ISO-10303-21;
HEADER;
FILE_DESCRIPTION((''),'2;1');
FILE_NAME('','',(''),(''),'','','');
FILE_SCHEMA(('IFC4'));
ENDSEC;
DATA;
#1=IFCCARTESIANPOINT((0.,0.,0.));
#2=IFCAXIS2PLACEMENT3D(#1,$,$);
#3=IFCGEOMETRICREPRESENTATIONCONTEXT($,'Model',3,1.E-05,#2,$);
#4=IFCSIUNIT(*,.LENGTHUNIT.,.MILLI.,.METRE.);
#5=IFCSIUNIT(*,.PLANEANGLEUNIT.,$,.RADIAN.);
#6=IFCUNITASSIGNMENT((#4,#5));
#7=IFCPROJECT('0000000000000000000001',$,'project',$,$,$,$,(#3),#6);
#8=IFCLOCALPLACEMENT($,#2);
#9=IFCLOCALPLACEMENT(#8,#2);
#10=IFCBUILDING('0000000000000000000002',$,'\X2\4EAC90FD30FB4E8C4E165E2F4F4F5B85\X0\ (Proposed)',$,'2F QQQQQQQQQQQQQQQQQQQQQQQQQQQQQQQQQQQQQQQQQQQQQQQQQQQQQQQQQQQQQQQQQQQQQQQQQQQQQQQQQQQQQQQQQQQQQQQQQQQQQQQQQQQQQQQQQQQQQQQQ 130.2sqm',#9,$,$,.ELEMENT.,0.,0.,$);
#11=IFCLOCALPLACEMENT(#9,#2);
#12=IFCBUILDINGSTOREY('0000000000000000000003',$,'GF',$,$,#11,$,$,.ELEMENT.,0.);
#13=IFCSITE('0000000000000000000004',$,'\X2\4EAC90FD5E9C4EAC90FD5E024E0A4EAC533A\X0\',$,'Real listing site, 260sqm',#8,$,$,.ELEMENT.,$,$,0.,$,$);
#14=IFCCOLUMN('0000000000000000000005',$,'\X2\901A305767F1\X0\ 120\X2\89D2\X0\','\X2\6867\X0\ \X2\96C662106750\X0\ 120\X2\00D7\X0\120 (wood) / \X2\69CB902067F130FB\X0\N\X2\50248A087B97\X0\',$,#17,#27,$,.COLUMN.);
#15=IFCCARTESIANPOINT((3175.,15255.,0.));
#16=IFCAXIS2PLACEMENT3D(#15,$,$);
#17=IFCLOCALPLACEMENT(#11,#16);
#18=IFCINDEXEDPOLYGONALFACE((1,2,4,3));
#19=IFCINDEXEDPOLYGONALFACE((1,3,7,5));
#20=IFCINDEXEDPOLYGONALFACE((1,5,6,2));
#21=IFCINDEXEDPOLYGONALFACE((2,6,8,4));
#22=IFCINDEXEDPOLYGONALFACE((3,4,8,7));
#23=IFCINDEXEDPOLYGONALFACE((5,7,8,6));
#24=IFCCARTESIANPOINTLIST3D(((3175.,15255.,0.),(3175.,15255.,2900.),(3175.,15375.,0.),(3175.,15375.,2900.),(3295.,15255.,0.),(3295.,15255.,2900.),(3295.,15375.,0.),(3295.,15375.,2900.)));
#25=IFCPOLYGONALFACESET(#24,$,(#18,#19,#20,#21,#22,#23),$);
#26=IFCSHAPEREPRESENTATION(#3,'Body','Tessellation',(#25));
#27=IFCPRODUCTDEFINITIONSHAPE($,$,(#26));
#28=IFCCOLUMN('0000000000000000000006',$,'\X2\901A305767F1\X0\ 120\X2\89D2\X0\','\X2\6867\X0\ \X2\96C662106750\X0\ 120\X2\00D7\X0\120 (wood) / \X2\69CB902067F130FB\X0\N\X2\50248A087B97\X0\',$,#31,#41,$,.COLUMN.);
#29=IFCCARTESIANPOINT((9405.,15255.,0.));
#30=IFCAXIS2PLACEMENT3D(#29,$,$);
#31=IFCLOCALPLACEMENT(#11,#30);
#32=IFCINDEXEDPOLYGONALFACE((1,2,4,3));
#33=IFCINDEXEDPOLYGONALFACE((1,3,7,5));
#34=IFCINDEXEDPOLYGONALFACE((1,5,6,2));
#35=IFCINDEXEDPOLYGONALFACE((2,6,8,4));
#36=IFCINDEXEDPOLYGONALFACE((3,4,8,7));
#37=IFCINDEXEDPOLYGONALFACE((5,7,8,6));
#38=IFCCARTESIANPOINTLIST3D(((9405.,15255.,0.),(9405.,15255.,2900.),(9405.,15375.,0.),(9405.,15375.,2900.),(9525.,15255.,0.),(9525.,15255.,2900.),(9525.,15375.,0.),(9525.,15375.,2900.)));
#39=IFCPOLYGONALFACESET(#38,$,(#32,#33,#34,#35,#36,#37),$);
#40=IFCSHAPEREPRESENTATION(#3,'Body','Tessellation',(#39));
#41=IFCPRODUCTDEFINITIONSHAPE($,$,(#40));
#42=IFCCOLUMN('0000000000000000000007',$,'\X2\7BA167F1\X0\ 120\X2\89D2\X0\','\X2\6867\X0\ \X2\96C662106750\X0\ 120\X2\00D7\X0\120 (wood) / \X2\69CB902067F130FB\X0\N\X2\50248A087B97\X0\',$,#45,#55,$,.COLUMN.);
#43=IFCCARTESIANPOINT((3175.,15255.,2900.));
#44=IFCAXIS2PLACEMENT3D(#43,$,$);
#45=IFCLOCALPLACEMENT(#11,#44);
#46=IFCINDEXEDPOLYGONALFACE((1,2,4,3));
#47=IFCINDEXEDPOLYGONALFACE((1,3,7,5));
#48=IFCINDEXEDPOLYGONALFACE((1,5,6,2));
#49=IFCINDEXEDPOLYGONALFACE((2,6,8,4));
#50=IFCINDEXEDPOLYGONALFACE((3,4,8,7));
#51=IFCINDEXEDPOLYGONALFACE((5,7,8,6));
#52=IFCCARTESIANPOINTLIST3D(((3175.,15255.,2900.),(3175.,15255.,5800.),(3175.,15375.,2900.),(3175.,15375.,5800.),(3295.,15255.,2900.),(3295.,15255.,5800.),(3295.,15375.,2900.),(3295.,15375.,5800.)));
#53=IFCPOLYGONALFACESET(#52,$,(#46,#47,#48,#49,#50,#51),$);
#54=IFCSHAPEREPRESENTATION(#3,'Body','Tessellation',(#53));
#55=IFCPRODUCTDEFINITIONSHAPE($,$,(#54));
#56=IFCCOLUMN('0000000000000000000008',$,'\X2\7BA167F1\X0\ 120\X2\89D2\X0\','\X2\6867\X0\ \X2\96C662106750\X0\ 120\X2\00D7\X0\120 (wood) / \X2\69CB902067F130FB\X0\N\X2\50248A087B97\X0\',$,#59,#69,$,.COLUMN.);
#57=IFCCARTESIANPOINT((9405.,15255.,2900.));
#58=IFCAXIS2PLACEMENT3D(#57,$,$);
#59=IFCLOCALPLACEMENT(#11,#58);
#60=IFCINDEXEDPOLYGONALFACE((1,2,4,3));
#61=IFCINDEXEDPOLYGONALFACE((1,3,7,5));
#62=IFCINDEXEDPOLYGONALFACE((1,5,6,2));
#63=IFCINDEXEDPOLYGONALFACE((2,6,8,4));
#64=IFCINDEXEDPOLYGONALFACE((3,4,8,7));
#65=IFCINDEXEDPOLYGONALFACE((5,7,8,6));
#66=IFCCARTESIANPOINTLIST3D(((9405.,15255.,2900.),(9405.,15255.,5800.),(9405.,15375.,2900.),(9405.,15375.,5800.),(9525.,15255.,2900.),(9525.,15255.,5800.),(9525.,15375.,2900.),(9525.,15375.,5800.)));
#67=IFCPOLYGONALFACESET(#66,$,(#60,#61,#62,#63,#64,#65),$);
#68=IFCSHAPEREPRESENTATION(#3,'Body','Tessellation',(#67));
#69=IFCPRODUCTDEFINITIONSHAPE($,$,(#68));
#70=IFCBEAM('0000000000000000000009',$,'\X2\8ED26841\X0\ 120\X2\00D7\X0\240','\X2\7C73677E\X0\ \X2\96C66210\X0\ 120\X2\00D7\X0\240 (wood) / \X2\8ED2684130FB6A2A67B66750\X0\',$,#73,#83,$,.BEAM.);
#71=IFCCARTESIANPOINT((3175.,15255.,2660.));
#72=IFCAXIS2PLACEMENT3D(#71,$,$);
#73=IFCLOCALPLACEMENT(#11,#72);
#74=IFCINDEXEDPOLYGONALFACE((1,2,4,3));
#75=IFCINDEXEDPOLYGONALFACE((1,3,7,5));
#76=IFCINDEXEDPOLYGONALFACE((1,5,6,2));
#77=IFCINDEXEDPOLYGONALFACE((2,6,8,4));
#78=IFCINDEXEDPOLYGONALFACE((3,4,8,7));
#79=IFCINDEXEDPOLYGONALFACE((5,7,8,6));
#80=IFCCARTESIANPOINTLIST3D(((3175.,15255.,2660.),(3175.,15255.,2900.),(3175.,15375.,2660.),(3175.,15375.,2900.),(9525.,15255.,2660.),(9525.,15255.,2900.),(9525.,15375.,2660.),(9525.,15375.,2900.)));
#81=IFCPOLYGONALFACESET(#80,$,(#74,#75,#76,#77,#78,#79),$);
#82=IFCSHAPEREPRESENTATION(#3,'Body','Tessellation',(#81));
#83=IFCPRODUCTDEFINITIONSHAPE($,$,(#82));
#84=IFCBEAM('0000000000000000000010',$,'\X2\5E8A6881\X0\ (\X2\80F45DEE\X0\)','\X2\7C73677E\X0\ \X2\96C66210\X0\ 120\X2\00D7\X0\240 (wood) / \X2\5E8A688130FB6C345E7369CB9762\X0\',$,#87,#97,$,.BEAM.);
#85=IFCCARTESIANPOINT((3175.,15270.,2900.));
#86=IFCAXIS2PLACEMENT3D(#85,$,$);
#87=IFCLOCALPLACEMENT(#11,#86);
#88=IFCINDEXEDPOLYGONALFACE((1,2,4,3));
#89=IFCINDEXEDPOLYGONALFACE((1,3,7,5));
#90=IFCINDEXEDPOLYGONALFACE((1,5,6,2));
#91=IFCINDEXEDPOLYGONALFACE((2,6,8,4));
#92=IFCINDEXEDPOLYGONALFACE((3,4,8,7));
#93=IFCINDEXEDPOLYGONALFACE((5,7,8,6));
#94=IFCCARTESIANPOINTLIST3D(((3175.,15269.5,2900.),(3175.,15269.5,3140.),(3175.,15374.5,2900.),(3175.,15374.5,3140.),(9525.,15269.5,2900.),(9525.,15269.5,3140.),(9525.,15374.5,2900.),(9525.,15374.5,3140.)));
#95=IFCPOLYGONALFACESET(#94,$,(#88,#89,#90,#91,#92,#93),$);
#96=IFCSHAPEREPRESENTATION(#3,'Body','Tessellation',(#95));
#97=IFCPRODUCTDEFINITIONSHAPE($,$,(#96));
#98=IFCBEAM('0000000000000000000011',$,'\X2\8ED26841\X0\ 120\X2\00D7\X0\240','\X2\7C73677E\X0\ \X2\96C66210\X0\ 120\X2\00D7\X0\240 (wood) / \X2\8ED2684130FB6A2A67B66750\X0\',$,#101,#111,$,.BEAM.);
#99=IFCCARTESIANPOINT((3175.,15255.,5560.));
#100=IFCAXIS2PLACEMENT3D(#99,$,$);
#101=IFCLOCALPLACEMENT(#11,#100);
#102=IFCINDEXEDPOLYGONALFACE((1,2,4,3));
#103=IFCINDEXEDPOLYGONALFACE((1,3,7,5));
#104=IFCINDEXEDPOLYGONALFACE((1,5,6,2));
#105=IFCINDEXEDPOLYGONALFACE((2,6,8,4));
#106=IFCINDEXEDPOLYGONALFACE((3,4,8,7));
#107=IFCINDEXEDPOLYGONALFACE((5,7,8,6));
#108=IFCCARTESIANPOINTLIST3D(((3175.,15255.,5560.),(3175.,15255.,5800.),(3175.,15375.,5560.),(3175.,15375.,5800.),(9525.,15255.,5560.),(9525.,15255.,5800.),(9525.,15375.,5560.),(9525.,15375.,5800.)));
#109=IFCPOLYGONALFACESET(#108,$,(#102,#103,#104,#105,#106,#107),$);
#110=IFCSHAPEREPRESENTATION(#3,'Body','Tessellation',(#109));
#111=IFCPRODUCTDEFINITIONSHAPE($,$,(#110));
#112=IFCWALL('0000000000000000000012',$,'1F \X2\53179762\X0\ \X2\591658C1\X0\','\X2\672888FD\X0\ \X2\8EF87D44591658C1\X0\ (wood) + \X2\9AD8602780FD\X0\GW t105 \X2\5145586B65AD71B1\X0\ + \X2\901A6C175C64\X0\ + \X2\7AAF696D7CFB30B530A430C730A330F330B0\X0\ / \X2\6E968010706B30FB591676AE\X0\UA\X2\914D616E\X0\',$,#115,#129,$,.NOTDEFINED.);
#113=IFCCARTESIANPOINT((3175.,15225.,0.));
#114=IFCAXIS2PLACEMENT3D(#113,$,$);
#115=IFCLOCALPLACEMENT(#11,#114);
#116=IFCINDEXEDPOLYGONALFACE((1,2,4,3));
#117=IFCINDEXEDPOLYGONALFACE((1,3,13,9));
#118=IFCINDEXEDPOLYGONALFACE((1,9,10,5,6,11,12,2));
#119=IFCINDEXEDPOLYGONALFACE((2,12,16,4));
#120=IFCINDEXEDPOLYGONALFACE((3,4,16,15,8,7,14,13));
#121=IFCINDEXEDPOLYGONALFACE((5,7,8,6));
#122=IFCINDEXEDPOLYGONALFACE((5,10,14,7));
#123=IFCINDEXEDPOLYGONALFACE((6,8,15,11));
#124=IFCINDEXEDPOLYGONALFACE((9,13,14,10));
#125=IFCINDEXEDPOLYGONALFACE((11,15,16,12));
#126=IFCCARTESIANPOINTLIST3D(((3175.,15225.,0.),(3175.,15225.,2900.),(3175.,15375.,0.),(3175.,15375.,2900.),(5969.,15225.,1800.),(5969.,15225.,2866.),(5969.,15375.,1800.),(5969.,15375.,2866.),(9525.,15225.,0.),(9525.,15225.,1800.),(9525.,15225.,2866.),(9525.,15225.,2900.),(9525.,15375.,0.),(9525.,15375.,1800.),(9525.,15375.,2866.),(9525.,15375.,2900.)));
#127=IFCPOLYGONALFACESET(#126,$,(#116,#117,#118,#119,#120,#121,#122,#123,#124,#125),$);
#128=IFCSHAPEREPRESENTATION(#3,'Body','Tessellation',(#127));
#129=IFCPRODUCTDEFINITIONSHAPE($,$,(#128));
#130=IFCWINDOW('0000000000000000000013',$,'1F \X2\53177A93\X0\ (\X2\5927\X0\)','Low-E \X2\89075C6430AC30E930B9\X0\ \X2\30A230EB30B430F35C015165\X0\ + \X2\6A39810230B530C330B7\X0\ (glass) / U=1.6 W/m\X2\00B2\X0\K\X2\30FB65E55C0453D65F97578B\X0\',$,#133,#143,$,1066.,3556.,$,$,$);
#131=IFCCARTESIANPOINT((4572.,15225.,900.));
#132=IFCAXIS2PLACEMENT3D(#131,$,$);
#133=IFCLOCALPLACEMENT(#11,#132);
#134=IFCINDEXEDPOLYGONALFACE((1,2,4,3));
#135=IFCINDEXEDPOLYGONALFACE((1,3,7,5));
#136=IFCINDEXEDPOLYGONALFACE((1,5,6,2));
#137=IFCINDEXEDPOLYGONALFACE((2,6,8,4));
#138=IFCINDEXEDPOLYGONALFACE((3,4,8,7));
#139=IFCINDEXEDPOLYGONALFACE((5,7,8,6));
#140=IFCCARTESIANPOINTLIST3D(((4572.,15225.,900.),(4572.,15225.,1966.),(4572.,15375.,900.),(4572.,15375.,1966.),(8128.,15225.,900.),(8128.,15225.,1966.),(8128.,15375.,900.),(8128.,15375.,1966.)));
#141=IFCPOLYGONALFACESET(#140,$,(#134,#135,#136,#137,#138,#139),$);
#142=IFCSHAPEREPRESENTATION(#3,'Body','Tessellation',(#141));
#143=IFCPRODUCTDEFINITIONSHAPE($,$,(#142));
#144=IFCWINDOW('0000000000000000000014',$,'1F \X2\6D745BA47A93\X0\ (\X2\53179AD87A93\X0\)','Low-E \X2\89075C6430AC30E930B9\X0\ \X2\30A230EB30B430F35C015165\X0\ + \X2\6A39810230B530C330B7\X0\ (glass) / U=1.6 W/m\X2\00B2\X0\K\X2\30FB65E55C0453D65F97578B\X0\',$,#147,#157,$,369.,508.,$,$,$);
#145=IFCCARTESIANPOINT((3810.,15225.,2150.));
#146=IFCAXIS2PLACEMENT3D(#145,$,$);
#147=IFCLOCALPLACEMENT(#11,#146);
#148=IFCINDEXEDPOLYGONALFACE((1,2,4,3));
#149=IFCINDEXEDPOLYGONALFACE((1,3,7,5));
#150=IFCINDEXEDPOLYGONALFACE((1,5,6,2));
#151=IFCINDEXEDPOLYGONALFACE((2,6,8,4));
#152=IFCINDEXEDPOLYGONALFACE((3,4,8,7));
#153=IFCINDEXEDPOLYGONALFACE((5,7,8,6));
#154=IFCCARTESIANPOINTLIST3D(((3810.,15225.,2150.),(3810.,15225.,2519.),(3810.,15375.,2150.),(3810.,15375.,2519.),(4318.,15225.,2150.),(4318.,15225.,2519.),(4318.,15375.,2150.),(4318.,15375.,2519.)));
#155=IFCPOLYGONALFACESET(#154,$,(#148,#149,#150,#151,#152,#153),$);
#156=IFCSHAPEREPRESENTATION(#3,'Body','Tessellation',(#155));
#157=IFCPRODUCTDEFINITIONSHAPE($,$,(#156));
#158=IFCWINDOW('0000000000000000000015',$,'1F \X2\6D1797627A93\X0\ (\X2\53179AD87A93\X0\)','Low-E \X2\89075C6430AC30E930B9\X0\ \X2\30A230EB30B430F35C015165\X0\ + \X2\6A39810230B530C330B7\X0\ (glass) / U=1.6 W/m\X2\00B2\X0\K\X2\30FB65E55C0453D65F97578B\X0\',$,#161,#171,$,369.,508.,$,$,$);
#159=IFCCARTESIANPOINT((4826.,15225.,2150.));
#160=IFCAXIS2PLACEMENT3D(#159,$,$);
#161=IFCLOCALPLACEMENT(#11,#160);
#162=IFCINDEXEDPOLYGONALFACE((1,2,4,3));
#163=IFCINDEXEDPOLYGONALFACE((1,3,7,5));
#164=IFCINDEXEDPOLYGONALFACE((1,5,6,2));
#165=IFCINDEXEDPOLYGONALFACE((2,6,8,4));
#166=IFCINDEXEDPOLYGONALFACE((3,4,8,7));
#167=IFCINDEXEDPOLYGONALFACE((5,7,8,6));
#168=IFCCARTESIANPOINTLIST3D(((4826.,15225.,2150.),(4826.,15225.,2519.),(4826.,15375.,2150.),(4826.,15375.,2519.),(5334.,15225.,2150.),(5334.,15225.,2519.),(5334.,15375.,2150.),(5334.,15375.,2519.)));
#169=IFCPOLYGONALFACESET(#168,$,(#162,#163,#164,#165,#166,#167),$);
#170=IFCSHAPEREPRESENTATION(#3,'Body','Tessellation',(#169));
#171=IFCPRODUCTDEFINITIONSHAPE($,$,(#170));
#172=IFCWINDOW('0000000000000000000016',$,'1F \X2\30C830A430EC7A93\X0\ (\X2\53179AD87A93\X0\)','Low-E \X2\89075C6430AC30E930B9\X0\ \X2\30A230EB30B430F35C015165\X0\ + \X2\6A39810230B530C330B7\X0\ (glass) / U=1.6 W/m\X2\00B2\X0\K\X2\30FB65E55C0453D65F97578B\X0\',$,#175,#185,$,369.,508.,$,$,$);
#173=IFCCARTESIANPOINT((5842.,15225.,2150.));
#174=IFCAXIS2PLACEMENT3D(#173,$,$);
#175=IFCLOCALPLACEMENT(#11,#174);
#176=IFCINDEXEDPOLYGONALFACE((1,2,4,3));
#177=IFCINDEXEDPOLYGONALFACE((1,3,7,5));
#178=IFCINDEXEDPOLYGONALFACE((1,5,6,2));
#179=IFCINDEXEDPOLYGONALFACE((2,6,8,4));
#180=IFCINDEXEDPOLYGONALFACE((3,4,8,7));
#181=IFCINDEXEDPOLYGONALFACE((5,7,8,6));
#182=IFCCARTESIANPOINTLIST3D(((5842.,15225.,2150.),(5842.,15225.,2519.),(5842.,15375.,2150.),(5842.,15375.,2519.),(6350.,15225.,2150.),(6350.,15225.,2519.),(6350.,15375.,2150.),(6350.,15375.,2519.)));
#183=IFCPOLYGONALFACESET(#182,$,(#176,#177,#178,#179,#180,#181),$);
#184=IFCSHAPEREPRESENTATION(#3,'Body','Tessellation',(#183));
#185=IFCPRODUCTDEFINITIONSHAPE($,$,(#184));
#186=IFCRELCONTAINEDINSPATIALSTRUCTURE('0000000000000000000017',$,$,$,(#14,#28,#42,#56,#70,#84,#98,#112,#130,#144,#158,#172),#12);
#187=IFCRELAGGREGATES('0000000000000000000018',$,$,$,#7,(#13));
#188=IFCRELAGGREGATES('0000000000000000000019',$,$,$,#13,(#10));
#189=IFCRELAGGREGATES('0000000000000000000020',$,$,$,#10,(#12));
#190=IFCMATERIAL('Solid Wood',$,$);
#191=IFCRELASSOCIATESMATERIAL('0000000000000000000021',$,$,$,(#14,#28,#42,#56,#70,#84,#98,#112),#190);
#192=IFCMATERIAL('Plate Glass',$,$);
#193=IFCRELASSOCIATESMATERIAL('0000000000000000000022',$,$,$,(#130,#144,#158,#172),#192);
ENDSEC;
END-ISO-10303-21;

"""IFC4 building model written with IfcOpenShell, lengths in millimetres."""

from ifc_helpers import new_model, si_unit, frame, frame_2d, origin, place, context, project, spatial, rectangle, extrude, material, element, fill, save


model = new_model("IFC4")

# Units and contexts
model_context = context("Model", 3, precision=1e-05, world=origin())
ifc_project = project(units=[si_unit("LENGTHUNIT", "METRE", prefix="MILLI"), si_unit("PLANEANGLEUNIT", "RADIAN")], contexts=[model_context])

# Site, building, storey
site_placement = place(None, origin())
site = spatial("IfcSite", under=ifc_project, at=site_placement, Name="京都府京都市上京区", ObjectType="Real listing site, 260sqm", CompositionType="ELEMENT", RefElevation=0.0)
building_placement = place(site_placement, origin())
building = spatial("IfcBuilding", under=site, at=building_placement, Name="京都・二世帯住宅 (Proposed)", ObjectType="2F QQQQQQQQQQQQQQQQQQQQQQQQQQQQQQQQQQQQQQQQQQQQQQQQQQQQQQQQQQQQQQQQQQQQQQQQQQQQQQQQQQQQQQQQQQQQQQQQQQQQQQQQQQQQQQQQQQQQQQQQ 130.2sqm", CompositionType="ELEMENT", ElevationOfRefHeight=0.0, ElevationOfTerrain=0.0)
storey_placement = place(building_placement, origin())
storey = spatial("IfcBuildingStorey", under=building, at=storey_placement, Name="GF", CompositionType="ELEMENT", Elevation=0.0)

# Columns
ifc_material_1 = material(Name="Solid Wood")
column_1_placement = place(storey_placement, frame((3175.0, 15255.0, 0.0)))
element("IfcColumn", 1, at=column_1_placement, inside=storey, material=ifc_material_1, Name="通し柱 120角", Description="桧 集成材 120×120 (wood) / 構造柱・N値計算", PredefinedType="COLUMN", context=model_context, shape_type="SweptSolid", body=[
    extrude(rectangle(XDim=120.0, YDim=120.0, at=frame_2d((60.0, 60.0))), frame((3175.0, 15255.0, 0.0)), (0.0, 0.0, 1.0), 2900.0),
])
column_2_placement = place(storey_placement, frame((9405.0, 15255.0, 0.0)))
element("IfcColumn", 2, at=column_2_placement, inside=storey, material=ifc_material_1, Name="通し柱 120角", Description="桧 集成材 120×120 (wood) / 構造柱・N値計算", PredefinedType="COLUMN", context=model_context, shape_type="SweptSolid", body=[
    extrude(rectangle(XDim=120.0, YDim=120.0, at=frame_2d((60.0, 60.0))), frame((9405.0, 15255.0, 0.0)), (0.0, 0.0, 1.0), 2900.0),
])
column_3_placement = place(storey_placement, frame((3175.0, 15255.0, 2900.0)))
element("IfcColumn", 3, at=column_3_placement, inside=storey, material=ifc_material_1, Name="管柱 120角", Description="桧 集成材 120×120 (wood) / 構造柱・N値計算", PredefinedType="COLUMN", context=model_context, shape_type="SweptSolid", body=[
    extrude(rectangle(XDim=120.0, YDim=120.0, at=frame_2d((60.0, 60.0))), frame((3175.0, 15255.0, 2900.0)), (0.0, 0.0, 1.0), 2900.0),
])
column_4_placement = place(storey_placement, frame((9405.0, 15255.0, 2900.0)))
element("IfcColumn", 4, at=column_4_placement, inside=storey, material=ifc_material_1, Name="管柱 120角", Description="桧 集成材 120×120 (wood) / 構造柱・N値計算", PredefinedType="COLUMN", context=model_context, shape_type="SweptSolid", body=[
    extrude(rectangle(XDim=120.0, YDim=120.0, at=frame_2d((60.0, 60.0))), frame((9405.0, 15255.0, 2900.0)), (0.0, 0.0, 1.0), 2900.0),
])

# Beams
beam_1_placement = place(storey_placement, frame((3175.0, 15255.0, 2660.0)))
element("IfcBeam", 5, at=beam_1_placement, inside=storey, material=ifc_material_1, Name="軒桁 120×240", Description="米松 集成 120×240 (wood) / 軒桁・横架材", PredefinedType="BEAM", context=model_context, shape_type="SweptSolid", body=[
    extrude(rectangle(XDim=6350.0, YDim=120.0, at=frame_2d((3175.0, 60.0))), frame((3175.0, 15255.0, 2660.0)), (0.0, 0.0, 1.0), 240.0),
])
beam_2_placement = place(storey_placement, frame((3175.0, 15270.0, 2900.0)))
element("IfcBeam", 6, at=beam_2_placement, inside=storey, material=ifc_material_1, Name="床梁 (胴差)", Description="米松 集成 120×240 (wood) / 床梁・水平構面", PredefinedType="BEAM", context=model_context, shape_type="SweptSolid", body=[
    extrude(rectangle(XDim=6350.0, YDim=105.0, at=frame_2d((3175.0, 52.0))), frame((3175.0, 15270.0, 2900.0)), (0.0, 0.0, 1.0), 240.0),
])
beam_3_placement = place(storey_placement, frame((3175.0, 15255.0, 5560.0)))
element("IfcBeam", 7, at=beam_3_placement, inside=storey, material=ifc_material_1, Name="軒桁 120×240", Description="米松 集成 120×240 (wood) / 軒桁・横架材", PredefinedType="BEAM", context=model_context, shape_type="SweptSolid", body=[
    extrude(rectangle(XDim=6350.0, YDim=120.0, at=frame_2d((3175.0, 60.0))), frame((3175.0, 15255.0, 5560.0)), (0.0, 0.0, 1.0), 240.0),
])

# Wall, openings, windows
wall_1_placement = place(storey_placement, frame((3175.0, 15225.0, 0.0)))
wall_1 = element("IfcWall", 8, at=wall_1_placement, inside=storey, material=ifc_material_1, Name="1F 北面 外壁", Description="木製 軸組外壁 (wood) + 高性能GW t105 充填断熱 + 通気層 + 窯業系サイディング / 準耐火・外皮UA配慮", PredefinedType="NOTDEFINED", context=model_context, shape_type="SweptSolid", body=[
    extrude(rectangle(XDim=6350.0, YDim=150.0, at=frame_2d((3175.0, 75.0))), frame((3175.0, 15225.0, 0.0)), (0.0, 0.0, 1.0), 2900.0),
])
opening_1_placement = place(storey_placement, frame((4572.0, 15225.0, 900.0)))
opening_1 = element("IfcOpeningElement", 9, at=opening_1_placement, cuts=wall_1, PredefinedType="NOTDEFINED", context=model_context, shape_type="SweptSolid", body=[
    extrude(rectangle(XDim=3556.0, YDim=150.0, at=frame_2d((1778.0, 75.0))), frame((4572.0, 15225.0, 900.0)), (0.0, 0.0, 1.0), 1066.0),
])
opening_2_placement = place(storey_placement, frame((3810.0, 15225.0, 2150.0)))
opening_2 = element("IfcOpeningElement", 10, at=opening_2_placement, cuts=wall_1, PredefinedType="NOTDEFINED", context=model_context, shape_type="SweptSolid", body=[
    extrude(rectangle(XDim=508.0, YDim=150.0, at=frame_2d((254.0, 75.0))), frame((3810.0, 15225.0, 2150.0)), (0.0, 0.0, 1.0), 369.0),
])
opening_3_placement = place(storey_placement, frame((4826.0, 15225.0, 2150.0)))
opening_3 = element("IfcOpeningElement", 11, at=opening_3_placement, cuts=wall_1, PredefinedType="NOTDEFINED", context=model_context, shape_type="SweptSolid", body=[
    extrude(rectangle(XDim=508.0, YDim=150.0, at=frame_2d((254.0, 75.0))), frame((4826.0, 15225.0, 2150.0)), (0.0, 0.0, 1.0), 369.0),
])
opening_4_placement = place(storey_placement, frame((5842.0, 15225.0, 2150.0)))
opening_4 = element("IfcOpeningElement", 12, at=opening_4_placement, cuts=wall_1, PredefinedType="NOTDEFINED", context=model_context, shape_type="SweptSolid", body=[
    extrude(rectangle(XDim=508.0, YDim=150.0, at=frame_2d((254.0, 75.0))), frame((5842.0, 15225.0, 2150.0)), (0.0, 0.0, 1.0), 369.0),
])
ifc_material_2 = material(Name="Plate Glass")
window_1_placement = place(storey_placement, frame((4572.0, 15225.0, 900.0)))
window_1 = element("IfcWindow", 13, at=window_1_placement, inside=storey, material=ifc_material_2, Name="1F 北窓 (大)", Description="Low-E 複層ガラス アルゴン封入 + 樹脂サッシ (glass) / U=1.6 W/m²K・日射取得型", OverallHeight=1066.0, OverallWidth=3556.0, context=model_context, shape_type="SweptSolid", body=[
    extrude(rectangle(XDim=3556.0, YDim=150.0, at=frame_2d((1778.0, 75.0))), frame((4572.0, 15225.0, 900.0)), (0.0, 0.0, 1.0), 1066.0),
])
fill(opening_1, window_1)
window_2_placement = place(storey_placement, frame((3810.0, 15225.0, 2150.0)))
window_2 = element("IfcWindow", 14, at=window_2_placement, inside=storey, material=ifc_material_2, Name="1F 浴室窓 (北高窓)", Description="Low-E 複層ガラス アルゴン封入 + 樹脂サッシ (glass) / U=1.6 W/m²K・日射取得型", OverallHeight=369.0, OverallWidth=508.0, context=model_context, shape_type="SweptSolid", body=[
    extrude(rectangle(XDim=508.0, YDim=150.0, at=frame_2d((254.0, 75.0))), frame((3810.0, 15225.0, 2150.0)), (0.0, 0.0, 1.0), 369.0),
])
fill(opening_2, window_2)
window_3_placement = place(storey_placement, frame((4826.0, 15225.0, 2150.0)))
window_3 = element("IfcWindow", 15, at=window_3_placement, inside=storey, material=ifc_material_2, Name="1F 洗面窓 (北高窓)", Description="Low-E 複層ガラス アルゴン封入 + 樹脂サッシ (glass) / U=1.6 W/m²K・日射取得型", OverallHeight=369.0, OverallWidth=508.0, context=model_context, shape_type="SweptSolid", body=[
    extrude(rectangle(XDim=508.0, YDim=150.0, at=frame_2d((254.0, 75.0))), frame((4826.0, 15225.0, 2150.0)), (0.0, 0.0, 1.0), 369.0),
])
fill(opening_3, window_3)
window_4_placement = place(storey_placement, frame((5842.0, 15225.0, 2150.0)))
window_4 = element("IfcWindow", 16, at=window_4_placement, inside=storey, material=ifc_material_2, Name="1F トイレ窓 (北高窓)", Description="Low-E 複層ガラス アルゴン封入 + 樹脂サッシ (glass) / U=1.6 W/m²K・日射取得型", OverallHeight=369.0, OverallWidth=508.0, context=model_context, shape_type="SweptSolid", body=[
    extrude(rectangle(XDim=508.0, YDim=150.0, at=frame_2d((254.0, 75.0))), frame((5842.0, 15225.0, 2150.0)), (0.0, 0.0, 1.0), 369.0),
])
fill(opening_4, window_4)

save(model, "model.ifc")
